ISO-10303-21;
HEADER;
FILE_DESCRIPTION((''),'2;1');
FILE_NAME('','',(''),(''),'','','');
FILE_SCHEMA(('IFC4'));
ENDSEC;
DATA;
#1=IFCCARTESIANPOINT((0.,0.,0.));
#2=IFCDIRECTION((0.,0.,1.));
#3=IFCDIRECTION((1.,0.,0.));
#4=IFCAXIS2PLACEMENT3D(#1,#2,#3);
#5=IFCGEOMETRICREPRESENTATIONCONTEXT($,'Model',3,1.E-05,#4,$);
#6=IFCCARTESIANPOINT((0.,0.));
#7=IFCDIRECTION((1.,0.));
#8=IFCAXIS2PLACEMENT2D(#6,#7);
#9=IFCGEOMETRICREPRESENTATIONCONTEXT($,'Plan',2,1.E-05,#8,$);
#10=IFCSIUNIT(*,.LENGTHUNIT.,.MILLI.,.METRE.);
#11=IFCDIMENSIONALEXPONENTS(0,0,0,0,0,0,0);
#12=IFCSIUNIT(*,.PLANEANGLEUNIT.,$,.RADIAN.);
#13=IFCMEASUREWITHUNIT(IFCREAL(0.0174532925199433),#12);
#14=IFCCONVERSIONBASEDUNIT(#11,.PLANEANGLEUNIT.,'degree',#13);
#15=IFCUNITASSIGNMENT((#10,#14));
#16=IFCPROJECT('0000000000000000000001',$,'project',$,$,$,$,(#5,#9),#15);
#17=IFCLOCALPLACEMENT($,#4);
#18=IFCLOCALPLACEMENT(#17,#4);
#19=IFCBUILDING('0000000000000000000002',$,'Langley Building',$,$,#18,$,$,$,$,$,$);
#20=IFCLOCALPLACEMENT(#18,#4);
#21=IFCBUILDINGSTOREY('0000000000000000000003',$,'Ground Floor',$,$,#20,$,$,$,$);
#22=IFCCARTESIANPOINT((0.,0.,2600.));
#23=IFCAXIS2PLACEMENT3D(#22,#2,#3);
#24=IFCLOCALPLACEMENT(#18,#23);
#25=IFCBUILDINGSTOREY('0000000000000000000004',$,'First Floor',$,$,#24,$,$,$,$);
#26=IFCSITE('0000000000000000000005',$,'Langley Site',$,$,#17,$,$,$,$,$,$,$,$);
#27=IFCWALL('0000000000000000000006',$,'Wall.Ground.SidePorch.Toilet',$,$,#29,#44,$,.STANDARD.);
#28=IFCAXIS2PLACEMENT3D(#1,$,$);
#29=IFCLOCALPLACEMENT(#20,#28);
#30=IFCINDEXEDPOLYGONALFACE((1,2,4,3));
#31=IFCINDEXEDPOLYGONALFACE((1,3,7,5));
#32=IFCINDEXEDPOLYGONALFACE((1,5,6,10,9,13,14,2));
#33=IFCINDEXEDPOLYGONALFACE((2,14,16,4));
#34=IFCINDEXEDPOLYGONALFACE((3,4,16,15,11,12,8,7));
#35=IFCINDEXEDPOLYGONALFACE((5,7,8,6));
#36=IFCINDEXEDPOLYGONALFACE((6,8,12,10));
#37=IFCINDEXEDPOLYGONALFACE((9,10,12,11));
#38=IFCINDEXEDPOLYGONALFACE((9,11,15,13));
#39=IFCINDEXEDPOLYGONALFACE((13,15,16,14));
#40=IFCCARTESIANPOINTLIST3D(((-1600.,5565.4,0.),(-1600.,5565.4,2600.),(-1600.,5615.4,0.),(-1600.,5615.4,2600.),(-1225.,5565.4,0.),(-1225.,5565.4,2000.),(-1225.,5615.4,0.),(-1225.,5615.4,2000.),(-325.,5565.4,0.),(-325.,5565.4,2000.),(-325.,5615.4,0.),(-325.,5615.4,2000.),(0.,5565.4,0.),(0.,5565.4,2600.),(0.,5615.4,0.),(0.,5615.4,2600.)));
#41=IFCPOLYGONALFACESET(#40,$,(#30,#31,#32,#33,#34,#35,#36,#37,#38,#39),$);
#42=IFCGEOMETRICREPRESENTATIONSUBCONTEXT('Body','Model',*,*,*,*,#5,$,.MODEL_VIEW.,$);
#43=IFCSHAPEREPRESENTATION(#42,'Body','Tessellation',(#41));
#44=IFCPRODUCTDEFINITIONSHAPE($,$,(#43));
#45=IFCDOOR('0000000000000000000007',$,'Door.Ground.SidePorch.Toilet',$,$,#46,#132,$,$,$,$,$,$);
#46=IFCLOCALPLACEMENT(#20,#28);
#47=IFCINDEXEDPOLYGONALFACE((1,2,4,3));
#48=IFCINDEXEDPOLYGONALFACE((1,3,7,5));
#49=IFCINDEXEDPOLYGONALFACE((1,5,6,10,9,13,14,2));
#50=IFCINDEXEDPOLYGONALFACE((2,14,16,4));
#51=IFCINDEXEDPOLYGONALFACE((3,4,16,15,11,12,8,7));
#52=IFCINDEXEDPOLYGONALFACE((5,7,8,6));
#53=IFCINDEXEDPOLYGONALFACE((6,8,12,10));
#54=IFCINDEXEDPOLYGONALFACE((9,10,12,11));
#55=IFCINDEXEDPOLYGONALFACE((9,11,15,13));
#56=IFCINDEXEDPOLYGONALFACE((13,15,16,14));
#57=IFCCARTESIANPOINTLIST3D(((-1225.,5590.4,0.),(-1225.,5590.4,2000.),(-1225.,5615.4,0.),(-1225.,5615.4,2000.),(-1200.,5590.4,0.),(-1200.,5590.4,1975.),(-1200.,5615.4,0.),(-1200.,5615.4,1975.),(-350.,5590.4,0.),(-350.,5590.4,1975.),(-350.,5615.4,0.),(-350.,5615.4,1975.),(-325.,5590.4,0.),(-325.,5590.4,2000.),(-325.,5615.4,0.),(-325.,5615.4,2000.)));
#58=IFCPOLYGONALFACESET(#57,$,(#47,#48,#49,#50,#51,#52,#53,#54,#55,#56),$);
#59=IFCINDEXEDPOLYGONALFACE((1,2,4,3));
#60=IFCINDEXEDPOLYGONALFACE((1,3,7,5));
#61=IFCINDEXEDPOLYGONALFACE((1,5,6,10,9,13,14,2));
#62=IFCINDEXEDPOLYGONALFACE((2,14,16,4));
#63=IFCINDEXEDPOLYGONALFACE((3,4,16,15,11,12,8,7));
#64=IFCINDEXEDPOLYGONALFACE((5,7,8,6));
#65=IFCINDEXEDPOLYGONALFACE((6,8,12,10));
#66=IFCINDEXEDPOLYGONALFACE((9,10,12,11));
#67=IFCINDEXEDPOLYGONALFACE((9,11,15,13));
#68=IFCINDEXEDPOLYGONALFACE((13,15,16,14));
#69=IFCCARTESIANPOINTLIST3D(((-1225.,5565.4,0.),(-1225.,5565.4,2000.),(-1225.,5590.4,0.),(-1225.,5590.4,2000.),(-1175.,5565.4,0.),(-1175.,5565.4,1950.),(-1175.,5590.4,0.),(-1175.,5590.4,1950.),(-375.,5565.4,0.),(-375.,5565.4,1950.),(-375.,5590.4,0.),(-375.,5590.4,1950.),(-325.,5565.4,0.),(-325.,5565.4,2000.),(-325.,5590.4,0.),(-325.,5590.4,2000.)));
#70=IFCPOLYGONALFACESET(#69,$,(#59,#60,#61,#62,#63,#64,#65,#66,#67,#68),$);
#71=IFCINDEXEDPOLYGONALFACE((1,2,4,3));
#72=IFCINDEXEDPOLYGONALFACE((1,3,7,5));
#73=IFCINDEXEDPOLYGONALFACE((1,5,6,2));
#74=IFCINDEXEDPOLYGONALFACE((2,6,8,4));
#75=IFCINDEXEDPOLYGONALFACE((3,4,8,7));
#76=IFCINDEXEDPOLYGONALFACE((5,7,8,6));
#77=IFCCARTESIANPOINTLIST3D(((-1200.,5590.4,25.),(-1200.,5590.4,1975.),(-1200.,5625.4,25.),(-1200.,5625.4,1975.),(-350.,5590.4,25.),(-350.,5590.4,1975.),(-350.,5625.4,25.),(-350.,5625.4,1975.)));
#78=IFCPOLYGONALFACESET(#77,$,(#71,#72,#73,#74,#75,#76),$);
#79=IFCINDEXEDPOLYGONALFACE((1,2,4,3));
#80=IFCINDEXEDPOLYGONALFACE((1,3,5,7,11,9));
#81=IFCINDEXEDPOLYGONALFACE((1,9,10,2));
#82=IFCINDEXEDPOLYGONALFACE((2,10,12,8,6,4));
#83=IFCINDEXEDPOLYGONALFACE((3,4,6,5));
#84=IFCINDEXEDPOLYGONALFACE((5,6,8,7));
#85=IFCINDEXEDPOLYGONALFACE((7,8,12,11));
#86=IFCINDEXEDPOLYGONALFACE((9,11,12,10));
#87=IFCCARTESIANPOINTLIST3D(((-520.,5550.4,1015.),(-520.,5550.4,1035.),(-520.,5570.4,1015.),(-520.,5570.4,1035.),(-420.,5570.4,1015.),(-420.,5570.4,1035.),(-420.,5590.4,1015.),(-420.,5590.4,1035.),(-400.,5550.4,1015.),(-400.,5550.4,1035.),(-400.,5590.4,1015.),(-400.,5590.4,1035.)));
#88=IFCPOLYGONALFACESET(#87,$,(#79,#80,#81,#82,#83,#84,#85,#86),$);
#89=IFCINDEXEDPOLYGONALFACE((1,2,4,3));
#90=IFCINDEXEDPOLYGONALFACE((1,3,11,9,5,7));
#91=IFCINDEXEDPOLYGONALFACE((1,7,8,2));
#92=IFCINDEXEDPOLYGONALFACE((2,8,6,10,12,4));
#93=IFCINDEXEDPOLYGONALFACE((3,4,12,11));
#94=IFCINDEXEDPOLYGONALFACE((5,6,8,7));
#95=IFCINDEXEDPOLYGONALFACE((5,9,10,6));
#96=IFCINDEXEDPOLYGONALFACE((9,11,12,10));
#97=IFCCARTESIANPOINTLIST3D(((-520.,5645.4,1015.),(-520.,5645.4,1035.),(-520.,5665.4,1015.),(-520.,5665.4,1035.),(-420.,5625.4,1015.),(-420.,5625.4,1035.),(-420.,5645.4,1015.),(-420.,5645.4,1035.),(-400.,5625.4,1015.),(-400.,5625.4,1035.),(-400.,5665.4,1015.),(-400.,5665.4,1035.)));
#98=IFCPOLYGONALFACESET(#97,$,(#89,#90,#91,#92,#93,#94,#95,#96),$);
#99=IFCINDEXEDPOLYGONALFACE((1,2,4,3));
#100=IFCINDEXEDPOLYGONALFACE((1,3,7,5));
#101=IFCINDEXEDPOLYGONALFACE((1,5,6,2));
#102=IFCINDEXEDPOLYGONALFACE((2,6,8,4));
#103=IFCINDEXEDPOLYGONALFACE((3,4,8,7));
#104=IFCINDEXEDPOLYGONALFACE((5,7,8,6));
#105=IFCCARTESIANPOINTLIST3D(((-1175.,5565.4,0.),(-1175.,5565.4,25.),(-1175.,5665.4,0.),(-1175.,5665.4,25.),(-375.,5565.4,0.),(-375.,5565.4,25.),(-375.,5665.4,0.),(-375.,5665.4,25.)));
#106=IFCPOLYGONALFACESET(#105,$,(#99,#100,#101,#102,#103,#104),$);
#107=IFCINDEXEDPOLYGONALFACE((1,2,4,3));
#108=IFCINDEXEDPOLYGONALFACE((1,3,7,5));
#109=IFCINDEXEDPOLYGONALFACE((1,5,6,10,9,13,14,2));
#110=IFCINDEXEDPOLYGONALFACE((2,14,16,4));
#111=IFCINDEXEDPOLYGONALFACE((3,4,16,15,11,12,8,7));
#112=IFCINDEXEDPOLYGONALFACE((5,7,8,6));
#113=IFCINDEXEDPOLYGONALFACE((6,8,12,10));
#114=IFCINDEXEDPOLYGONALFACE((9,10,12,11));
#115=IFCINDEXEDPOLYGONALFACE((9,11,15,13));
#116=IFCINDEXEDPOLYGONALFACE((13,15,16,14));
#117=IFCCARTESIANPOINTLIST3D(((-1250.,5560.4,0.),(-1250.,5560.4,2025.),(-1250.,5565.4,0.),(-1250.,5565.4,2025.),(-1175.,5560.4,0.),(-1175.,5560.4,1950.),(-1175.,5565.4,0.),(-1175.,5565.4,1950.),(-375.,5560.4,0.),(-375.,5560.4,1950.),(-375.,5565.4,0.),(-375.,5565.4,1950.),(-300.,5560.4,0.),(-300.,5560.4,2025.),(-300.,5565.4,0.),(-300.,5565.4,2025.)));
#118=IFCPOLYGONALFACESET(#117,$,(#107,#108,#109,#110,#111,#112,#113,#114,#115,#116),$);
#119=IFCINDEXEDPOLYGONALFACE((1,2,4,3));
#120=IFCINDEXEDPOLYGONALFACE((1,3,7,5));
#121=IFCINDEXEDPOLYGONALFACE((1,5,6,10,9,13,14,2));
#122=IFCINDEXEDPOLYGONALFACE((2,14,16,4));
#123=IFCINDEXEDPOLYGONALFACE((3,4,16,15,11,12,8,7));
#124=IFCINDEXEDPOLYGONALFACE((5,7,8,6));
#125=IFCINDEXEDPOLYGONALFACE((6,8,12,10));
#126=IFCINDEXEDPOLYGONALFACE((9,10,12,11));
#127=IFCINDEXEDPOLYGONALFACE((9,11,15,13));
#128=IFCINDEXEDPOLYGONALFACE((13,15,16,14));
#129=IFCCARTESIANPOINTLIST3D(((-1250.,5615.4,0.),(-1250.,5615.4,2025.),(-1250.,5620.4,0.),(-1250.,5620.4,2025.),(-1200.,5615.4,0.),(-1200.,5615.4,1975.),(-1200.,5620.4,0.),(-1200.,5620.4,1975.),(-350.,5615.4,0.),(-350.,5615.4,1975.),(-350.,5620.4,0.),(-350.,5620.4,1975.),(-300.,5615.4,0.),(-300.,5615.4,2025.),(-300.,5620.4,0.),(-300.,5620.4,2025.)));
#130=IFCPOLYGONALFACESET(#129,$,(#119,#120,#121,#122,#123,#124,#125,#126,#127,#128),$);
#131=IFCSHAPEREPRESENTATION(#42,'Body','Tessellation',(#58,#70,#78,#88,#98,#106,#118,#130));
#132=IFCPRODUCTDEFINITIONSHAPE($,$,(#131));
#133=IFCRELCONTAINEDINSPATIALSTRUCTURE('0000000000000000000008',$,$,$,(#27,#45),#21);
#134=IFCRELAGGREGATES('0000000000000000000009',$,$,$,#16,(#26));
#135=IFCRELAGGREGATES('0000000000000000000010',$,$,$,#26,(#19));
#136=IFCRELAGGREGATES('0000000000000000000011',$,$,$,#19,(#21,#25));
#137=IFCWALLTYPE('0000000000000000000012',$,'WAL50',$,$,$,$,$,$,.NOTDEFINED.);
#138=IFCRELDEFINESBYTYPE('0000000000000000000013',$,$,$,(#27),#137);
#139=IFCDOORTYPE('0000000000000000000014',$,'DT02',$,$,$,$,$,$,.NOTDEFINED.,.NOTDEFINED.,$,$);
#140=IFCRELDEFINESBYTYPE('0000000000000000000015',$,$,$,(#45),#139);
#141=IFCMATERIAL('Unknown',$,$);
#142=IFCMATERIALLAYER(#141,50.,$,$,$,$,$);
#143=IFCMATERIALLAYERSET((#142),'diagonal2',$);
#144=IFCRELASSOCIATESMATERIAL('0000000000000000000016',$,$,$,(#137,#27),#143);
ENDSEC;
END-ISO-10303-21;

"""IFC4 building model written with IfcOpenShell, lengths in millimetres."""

from ifc_helpers import new_model, entity, si_unit, converted_unit, frame, origin_with_axes, origin_2d_with_axis, place, context, subcontext, project, spatial, line, indexed_curve, outline, extrude, shape, source, transform, mapped, material, layer, layer_set, layer_usage, type_object, type_shapes, element, fill, save


model = new_model("IFC4")

# Units and contexts
model_context = context("Model", 3, precision=1e-05, world=origin_with_axes())
plan_context = context("Plan", 2, precision=1e-05, world=origin_2d_with_axis())
body_context_1 = subcontext(model_context, "Body", "Model", "MODEL_VIEW")
body_context_2 = subcontext(plan_context, "Body", "Plan", "PLAN_VIEW")
ifc_project = project(units=[si_unit("LENGTHUNIT", "METRE", prefix="MILLI"), converted_unit("PLANEANGLEUNIT", "degree", entity("IfcReal", 0.0174532925199433), si_unit("PLANEANGLEUNIT", "RADIAN"), dimensions=[0, 0, 0, 0, 0, 0, 0])], contexts=[model_context, plan_context])

# Site, building, storey
site_placement = place(None, origin_with_axes())
site = spatial("IfcSite", under=ifc_project, at=site_placement, Name="Langley Site")
building_placement = place(site_placement, origin_with_axes())
building = spatial("IfcBuilding", under=site, at=building_placement, Name="Langley Building")
storey_1_placement = place(building_placement, origin_with_axes())
storey_1 = spatial("IfcBuildingStorey", under=building, at=storey_1_placement, Name="Ground Floor")

# Wall, opening, door
ifc_material = material(Name="Unknown")
ifc_layer_1 = layer(ifc_material, 50.0)
ifc_layer_set_1 = layer_set([ifc_layer_1], Name="diagonal2")
ifc_layer_usage_1 = layer_usage(ifc_layer_set_1, "AXIS2", "POSITIVE", 0.0)
wall_type_1 = type_object("IfcWallType", Name="WAL50", PredefinedType="NOTDEFINED", material=ifc_layer_set_1)
wall_1_placement = place(storey_1_placement, frame((0.0, 5615.4, 0.0), z_axis=(0.0, 0.0, 1.0), x_axis=(-1.0, 0.0, 0.0)))
wall_1 = element("IfcWall", 1, at=wall_1_placement, inside=storey_1, type_object=wall_type_1, material=ifc_layer_usage_1, Name="Wall.Ground.SidePorch.Toilet", PredefinedType="STANDARD", context=body_context_1, shape_type="SweptSolid", body=[
    extrude(outline(indexed_curve([(0.0, 0.0), (0.0, 50.0), (1600.0, 50.0), (1600.0, 0.0)], segments=[line(1, 2, 3, 4, 1)])), origin_with_axes(), (0.0, 0.0, 1.0), 2600.0),
])
shared_shape_1 = source(origin_with_axes(), body_context_1, "Body", "SweptSolid", [
    extrude(outline(indexed_curve([(0.0, 0.0), (900.0, 0.0), (900.0, 2000.0), (0.0, 2000.0)], segments=[line(1, 2, 3, 4, 1)])), frame((0.0, -600.0, 0.0), z_axis=(0.0, -1.0, 0.0), x_axis=(1.0, 0.0, 0.0)), (0.0, 0.0, -1.0), 1200.0),
])
opening_1_placement = place(wall_1_placement, frame((325.0, 0.0, 0.0), z_axis=(0.0, 0.0, 1.0), x_axis=(1.0, 0.0, 0.0)))
opening_1 = element("IfcOpeningElement", 2, at=opening_1_placement, cuts=wall_1, PredefinedType="OPENING", context=body_context_1, shape_type="MappedRepresentation", body=[
    mapped(shared_shape_1, transform((0.0, 0.0, 0.0), x_axis=(1.0, 0.0, 0.0), y_axis=(0.0, 1.0, 0.0), z_axis=(0.0, 0.0, 1.0), scale=1.0)),
])
door_type_1 = type_object("IfcDoorType", Name="DT02", OperationType="NOTDEFINED", PredefinedType="NOTDEFINED")
shared_shape_2 = source(origin_with_axes(), body_context_1, "Body", "SweptSolid", [
    extrude(outline(indexed_curve([(0.0, 0.0), (0.0, 2000.0), (900.0, 2000.0), (900.0, 0.0), (875.0, 0.0), (875.0, 1975.0), (25.0, 1975.0), (25.0, 0.0)], segments=[line(1, 2, 3, 4, 5, 6, 7, 8, 1)])), frame((0.0, 25.0, 0.0), z_axis=(0.0, -1.0, 0.0), x_axis=(1.0, 0.0, 0.0)), (0.0, 0.0, -1.0), 25.0),
    extrude(outline(indexed_curve([(0.0, 0.0), (0.0, 2000.0), (900.0, 2000.0), (900.0, 0.0), (850.0, 0.0), (850.0, 1950.0), (50.0, 1950.0), (50.0, 0.0)], segments=[line(1, 2, 3, 4, 5, 6, 7, 8, 1)])), frame((0.0, 0.0, 0.0), z_axis=(0.0, -1.0, 0.0), x_axis=(1.0, 0.0, 0.0)), (0.0, 0.0, -1.0), 25.0),
    extrude(outline(indexed_curve([(0.0, 0.0), (850.0, 0.0), (850.0, 35.0), (0.0, 35.0)], segments=[line(1, 2, 3, 4, 1)])), frame((25.0, 25.0, 25.0), z_axis=(0.0, 0.0, 1.0), x_axis=(1.0, 0.0, 0.0)), (0.0, 0.0, 1.0), 1950.0),
    extrude(outline(indexed_curve([(0.0, 0.0), (0.0, -40.0), (-120.0, -40.0), (-120.0, -20.0), (-20.0, -20.0), (-20.0, 0.0)], segments=[line(1, 2, 3, 4, 5, 6, 1)])), frame((825.0, 25.0, 1015.0), z_axis=(0.0, 0.0, 1.0), x_axis=(1.0, 0.0, 0.0)), (0.0, 0.0, 1.0), 20.0),
    extrude(outline(indexed_curve([(0.0, 0.0), (0.0, 40.0), (-120.0, 40.0), (-120.0, 20.0), (-20.0, 20.0), (-20.0, 0.0)], segments=[line(1, 2, 3, 4, 5, 6, 1)])), frame((825.0, 60.0, 1015.0), z_axis=(0.0, 0.0, 1.0), x_axis=(1.0, 0.0, 0.0)), (0.0, 0.0, 1.0), 20.0),
    extrude(outline(indexed_curve([(0.0, 0.0), (800.0, 0.0), (800.0, 100.0), (0.0, 100.0)], segments=[line(1, 2, 3, 4, 1)])), frame((50.0, 0.0, 0.0), z_axis=(0.0, 0.0, 1.0), x_axis=(1.0, 0.0, 0.0)), (0.0, 0.0, 1.0), 25.0),
    extrude(outline(indexed_curve([(0.0, 0.0), (0.0, 2025.0), (950.0, 2025.0), (950.0, 0.0), (875.0, 0.0), (875.0, 1950.0), (75.0, 1950.0), (75.0, 0.0)], segments=[line(1, 2, 3, 4, 5, 6, 7, 8, 1)])), frame((-25.0, -5.0, 0.0), z_axis=(0.0, -1.0, 0.0), x_axis=(1.0, 0.0, 0.0)), (0.0, 0.0, -1.0), 5.0),
    extrude(outline(indexed_curve([(0.0, 0.0), (0.0, 2025.0), (950.0, 2025.0), (950.0, 0.0), (900.0, 0.0), (900.0, 1975.0), (50.0, 1975.0), (50.0, 0.0)], segments=[line(1, 2, 3, 4, 5, 6, 7, 8, 1)])), frame((-25.0, 50.0, 0.0), z_axis=(0.0, -1.0, 0.0), x_axis=(1.0, 0.0, 0.0)), (0.0, 0.0, -1.0), 5.0),
])
shared_shape_3 = source(origin_with_axes(), body_context_2, "Body", "Curve2D", [
    entity("IfcIndexedPolyCurve", entity("IfcCartesianPointList2D", [[0.0, 0.0], [0.0, 50.0], [25.0, 50.0], [25.0, 25.0], [50.0, 25.0], [50.0, 0.0]]), [entity("IfcLineIndex", [1, 2, 3, 4, 5, 6, 1])]),
    entity("IfcIndexedPolyCurve", entity("IfcCartesianPointList2D", [[900.0, 0.0], [900.0, 50.0], [875.0, 50.0], [875.0, 25.0], [850.0, 25.0], [850.0, 0.0]]), [entity("IfcLineIndex", [1, 2, 3, 4, 5, 6, 1])]),
    entity("IfcTrimmedCurve", entity("IfcEllipse", entity("IfcAxis2Placement2D", entity("IfcCartesianPoint", [60.0, 50.0]), entity("IfcDirection", [1.0, 0.0])), 815.0, 850.0), [entity("IfcCartesianPoint", [875.0, 50.0])], [entity("IfcCartesianPoint", [60.0, 900.0])], True, "CARTESIAN"),
    entity("IfcIndexedPolyCurve", entity("IfcCartesianPointList2D", [[25.0, 50.0], [60.0, 50.0], [60.0, 900.0], [25.0, 900.0]]), [entity("IfcLineIndex", [1, 2, 3, 4, 1])]),
])
type_shapes(door_type_1, [shared_shape_2, shared_shape_3])
door_1_placement = place(opening_1_placement, frame((900.0, 50.0, 0.0), z_axis=(0.0, 0.0, 1.0), x_axis=(-1.0, 0.0, 0.0)))
door_1 = element("IfcDoor", 3, at=door_1_placement, inside=storey_1, type_object=door_type_1, Name="Door.Ground.SidePorch.Toilet", shapes=[
    shape(body_context_1, "Body", "MappedRepresentation", [mapped(shared_shape_2, transform((0.0, 0.0, 0.0), x_axis=(1.0, 0.0, 0.0), y_axis=(0.0, 1.0, 0.0), z_axis=(0.0, 0.0, 1.0), scale=1.0))]),
    shape(body_context_2, "Body", "MappedRepresentation", [mapped(shared_shape_3, transform((0.0, 0.0, 0.0), x_axis=(1.0, 0.0, 0.0), y_axis=(0.0, 1.0, 0.0), z_axis=(0.0, 0.0, 1.0), scale=1.0))]),
])
fill(opening_1, door_1)

# Shared definitions
storey_2_placement = place(building_placement, frame((0.0, 0.0, 2600.0), z_axis=(0.0, 0.0, 1.0), x_axis=(1.0, 0.0, 0.0)))
storey_2 = spatial("IfcBuildingStorey", under=building, at=storey_2_placement, Name="First Floor")

save(model, "model.ifc")
